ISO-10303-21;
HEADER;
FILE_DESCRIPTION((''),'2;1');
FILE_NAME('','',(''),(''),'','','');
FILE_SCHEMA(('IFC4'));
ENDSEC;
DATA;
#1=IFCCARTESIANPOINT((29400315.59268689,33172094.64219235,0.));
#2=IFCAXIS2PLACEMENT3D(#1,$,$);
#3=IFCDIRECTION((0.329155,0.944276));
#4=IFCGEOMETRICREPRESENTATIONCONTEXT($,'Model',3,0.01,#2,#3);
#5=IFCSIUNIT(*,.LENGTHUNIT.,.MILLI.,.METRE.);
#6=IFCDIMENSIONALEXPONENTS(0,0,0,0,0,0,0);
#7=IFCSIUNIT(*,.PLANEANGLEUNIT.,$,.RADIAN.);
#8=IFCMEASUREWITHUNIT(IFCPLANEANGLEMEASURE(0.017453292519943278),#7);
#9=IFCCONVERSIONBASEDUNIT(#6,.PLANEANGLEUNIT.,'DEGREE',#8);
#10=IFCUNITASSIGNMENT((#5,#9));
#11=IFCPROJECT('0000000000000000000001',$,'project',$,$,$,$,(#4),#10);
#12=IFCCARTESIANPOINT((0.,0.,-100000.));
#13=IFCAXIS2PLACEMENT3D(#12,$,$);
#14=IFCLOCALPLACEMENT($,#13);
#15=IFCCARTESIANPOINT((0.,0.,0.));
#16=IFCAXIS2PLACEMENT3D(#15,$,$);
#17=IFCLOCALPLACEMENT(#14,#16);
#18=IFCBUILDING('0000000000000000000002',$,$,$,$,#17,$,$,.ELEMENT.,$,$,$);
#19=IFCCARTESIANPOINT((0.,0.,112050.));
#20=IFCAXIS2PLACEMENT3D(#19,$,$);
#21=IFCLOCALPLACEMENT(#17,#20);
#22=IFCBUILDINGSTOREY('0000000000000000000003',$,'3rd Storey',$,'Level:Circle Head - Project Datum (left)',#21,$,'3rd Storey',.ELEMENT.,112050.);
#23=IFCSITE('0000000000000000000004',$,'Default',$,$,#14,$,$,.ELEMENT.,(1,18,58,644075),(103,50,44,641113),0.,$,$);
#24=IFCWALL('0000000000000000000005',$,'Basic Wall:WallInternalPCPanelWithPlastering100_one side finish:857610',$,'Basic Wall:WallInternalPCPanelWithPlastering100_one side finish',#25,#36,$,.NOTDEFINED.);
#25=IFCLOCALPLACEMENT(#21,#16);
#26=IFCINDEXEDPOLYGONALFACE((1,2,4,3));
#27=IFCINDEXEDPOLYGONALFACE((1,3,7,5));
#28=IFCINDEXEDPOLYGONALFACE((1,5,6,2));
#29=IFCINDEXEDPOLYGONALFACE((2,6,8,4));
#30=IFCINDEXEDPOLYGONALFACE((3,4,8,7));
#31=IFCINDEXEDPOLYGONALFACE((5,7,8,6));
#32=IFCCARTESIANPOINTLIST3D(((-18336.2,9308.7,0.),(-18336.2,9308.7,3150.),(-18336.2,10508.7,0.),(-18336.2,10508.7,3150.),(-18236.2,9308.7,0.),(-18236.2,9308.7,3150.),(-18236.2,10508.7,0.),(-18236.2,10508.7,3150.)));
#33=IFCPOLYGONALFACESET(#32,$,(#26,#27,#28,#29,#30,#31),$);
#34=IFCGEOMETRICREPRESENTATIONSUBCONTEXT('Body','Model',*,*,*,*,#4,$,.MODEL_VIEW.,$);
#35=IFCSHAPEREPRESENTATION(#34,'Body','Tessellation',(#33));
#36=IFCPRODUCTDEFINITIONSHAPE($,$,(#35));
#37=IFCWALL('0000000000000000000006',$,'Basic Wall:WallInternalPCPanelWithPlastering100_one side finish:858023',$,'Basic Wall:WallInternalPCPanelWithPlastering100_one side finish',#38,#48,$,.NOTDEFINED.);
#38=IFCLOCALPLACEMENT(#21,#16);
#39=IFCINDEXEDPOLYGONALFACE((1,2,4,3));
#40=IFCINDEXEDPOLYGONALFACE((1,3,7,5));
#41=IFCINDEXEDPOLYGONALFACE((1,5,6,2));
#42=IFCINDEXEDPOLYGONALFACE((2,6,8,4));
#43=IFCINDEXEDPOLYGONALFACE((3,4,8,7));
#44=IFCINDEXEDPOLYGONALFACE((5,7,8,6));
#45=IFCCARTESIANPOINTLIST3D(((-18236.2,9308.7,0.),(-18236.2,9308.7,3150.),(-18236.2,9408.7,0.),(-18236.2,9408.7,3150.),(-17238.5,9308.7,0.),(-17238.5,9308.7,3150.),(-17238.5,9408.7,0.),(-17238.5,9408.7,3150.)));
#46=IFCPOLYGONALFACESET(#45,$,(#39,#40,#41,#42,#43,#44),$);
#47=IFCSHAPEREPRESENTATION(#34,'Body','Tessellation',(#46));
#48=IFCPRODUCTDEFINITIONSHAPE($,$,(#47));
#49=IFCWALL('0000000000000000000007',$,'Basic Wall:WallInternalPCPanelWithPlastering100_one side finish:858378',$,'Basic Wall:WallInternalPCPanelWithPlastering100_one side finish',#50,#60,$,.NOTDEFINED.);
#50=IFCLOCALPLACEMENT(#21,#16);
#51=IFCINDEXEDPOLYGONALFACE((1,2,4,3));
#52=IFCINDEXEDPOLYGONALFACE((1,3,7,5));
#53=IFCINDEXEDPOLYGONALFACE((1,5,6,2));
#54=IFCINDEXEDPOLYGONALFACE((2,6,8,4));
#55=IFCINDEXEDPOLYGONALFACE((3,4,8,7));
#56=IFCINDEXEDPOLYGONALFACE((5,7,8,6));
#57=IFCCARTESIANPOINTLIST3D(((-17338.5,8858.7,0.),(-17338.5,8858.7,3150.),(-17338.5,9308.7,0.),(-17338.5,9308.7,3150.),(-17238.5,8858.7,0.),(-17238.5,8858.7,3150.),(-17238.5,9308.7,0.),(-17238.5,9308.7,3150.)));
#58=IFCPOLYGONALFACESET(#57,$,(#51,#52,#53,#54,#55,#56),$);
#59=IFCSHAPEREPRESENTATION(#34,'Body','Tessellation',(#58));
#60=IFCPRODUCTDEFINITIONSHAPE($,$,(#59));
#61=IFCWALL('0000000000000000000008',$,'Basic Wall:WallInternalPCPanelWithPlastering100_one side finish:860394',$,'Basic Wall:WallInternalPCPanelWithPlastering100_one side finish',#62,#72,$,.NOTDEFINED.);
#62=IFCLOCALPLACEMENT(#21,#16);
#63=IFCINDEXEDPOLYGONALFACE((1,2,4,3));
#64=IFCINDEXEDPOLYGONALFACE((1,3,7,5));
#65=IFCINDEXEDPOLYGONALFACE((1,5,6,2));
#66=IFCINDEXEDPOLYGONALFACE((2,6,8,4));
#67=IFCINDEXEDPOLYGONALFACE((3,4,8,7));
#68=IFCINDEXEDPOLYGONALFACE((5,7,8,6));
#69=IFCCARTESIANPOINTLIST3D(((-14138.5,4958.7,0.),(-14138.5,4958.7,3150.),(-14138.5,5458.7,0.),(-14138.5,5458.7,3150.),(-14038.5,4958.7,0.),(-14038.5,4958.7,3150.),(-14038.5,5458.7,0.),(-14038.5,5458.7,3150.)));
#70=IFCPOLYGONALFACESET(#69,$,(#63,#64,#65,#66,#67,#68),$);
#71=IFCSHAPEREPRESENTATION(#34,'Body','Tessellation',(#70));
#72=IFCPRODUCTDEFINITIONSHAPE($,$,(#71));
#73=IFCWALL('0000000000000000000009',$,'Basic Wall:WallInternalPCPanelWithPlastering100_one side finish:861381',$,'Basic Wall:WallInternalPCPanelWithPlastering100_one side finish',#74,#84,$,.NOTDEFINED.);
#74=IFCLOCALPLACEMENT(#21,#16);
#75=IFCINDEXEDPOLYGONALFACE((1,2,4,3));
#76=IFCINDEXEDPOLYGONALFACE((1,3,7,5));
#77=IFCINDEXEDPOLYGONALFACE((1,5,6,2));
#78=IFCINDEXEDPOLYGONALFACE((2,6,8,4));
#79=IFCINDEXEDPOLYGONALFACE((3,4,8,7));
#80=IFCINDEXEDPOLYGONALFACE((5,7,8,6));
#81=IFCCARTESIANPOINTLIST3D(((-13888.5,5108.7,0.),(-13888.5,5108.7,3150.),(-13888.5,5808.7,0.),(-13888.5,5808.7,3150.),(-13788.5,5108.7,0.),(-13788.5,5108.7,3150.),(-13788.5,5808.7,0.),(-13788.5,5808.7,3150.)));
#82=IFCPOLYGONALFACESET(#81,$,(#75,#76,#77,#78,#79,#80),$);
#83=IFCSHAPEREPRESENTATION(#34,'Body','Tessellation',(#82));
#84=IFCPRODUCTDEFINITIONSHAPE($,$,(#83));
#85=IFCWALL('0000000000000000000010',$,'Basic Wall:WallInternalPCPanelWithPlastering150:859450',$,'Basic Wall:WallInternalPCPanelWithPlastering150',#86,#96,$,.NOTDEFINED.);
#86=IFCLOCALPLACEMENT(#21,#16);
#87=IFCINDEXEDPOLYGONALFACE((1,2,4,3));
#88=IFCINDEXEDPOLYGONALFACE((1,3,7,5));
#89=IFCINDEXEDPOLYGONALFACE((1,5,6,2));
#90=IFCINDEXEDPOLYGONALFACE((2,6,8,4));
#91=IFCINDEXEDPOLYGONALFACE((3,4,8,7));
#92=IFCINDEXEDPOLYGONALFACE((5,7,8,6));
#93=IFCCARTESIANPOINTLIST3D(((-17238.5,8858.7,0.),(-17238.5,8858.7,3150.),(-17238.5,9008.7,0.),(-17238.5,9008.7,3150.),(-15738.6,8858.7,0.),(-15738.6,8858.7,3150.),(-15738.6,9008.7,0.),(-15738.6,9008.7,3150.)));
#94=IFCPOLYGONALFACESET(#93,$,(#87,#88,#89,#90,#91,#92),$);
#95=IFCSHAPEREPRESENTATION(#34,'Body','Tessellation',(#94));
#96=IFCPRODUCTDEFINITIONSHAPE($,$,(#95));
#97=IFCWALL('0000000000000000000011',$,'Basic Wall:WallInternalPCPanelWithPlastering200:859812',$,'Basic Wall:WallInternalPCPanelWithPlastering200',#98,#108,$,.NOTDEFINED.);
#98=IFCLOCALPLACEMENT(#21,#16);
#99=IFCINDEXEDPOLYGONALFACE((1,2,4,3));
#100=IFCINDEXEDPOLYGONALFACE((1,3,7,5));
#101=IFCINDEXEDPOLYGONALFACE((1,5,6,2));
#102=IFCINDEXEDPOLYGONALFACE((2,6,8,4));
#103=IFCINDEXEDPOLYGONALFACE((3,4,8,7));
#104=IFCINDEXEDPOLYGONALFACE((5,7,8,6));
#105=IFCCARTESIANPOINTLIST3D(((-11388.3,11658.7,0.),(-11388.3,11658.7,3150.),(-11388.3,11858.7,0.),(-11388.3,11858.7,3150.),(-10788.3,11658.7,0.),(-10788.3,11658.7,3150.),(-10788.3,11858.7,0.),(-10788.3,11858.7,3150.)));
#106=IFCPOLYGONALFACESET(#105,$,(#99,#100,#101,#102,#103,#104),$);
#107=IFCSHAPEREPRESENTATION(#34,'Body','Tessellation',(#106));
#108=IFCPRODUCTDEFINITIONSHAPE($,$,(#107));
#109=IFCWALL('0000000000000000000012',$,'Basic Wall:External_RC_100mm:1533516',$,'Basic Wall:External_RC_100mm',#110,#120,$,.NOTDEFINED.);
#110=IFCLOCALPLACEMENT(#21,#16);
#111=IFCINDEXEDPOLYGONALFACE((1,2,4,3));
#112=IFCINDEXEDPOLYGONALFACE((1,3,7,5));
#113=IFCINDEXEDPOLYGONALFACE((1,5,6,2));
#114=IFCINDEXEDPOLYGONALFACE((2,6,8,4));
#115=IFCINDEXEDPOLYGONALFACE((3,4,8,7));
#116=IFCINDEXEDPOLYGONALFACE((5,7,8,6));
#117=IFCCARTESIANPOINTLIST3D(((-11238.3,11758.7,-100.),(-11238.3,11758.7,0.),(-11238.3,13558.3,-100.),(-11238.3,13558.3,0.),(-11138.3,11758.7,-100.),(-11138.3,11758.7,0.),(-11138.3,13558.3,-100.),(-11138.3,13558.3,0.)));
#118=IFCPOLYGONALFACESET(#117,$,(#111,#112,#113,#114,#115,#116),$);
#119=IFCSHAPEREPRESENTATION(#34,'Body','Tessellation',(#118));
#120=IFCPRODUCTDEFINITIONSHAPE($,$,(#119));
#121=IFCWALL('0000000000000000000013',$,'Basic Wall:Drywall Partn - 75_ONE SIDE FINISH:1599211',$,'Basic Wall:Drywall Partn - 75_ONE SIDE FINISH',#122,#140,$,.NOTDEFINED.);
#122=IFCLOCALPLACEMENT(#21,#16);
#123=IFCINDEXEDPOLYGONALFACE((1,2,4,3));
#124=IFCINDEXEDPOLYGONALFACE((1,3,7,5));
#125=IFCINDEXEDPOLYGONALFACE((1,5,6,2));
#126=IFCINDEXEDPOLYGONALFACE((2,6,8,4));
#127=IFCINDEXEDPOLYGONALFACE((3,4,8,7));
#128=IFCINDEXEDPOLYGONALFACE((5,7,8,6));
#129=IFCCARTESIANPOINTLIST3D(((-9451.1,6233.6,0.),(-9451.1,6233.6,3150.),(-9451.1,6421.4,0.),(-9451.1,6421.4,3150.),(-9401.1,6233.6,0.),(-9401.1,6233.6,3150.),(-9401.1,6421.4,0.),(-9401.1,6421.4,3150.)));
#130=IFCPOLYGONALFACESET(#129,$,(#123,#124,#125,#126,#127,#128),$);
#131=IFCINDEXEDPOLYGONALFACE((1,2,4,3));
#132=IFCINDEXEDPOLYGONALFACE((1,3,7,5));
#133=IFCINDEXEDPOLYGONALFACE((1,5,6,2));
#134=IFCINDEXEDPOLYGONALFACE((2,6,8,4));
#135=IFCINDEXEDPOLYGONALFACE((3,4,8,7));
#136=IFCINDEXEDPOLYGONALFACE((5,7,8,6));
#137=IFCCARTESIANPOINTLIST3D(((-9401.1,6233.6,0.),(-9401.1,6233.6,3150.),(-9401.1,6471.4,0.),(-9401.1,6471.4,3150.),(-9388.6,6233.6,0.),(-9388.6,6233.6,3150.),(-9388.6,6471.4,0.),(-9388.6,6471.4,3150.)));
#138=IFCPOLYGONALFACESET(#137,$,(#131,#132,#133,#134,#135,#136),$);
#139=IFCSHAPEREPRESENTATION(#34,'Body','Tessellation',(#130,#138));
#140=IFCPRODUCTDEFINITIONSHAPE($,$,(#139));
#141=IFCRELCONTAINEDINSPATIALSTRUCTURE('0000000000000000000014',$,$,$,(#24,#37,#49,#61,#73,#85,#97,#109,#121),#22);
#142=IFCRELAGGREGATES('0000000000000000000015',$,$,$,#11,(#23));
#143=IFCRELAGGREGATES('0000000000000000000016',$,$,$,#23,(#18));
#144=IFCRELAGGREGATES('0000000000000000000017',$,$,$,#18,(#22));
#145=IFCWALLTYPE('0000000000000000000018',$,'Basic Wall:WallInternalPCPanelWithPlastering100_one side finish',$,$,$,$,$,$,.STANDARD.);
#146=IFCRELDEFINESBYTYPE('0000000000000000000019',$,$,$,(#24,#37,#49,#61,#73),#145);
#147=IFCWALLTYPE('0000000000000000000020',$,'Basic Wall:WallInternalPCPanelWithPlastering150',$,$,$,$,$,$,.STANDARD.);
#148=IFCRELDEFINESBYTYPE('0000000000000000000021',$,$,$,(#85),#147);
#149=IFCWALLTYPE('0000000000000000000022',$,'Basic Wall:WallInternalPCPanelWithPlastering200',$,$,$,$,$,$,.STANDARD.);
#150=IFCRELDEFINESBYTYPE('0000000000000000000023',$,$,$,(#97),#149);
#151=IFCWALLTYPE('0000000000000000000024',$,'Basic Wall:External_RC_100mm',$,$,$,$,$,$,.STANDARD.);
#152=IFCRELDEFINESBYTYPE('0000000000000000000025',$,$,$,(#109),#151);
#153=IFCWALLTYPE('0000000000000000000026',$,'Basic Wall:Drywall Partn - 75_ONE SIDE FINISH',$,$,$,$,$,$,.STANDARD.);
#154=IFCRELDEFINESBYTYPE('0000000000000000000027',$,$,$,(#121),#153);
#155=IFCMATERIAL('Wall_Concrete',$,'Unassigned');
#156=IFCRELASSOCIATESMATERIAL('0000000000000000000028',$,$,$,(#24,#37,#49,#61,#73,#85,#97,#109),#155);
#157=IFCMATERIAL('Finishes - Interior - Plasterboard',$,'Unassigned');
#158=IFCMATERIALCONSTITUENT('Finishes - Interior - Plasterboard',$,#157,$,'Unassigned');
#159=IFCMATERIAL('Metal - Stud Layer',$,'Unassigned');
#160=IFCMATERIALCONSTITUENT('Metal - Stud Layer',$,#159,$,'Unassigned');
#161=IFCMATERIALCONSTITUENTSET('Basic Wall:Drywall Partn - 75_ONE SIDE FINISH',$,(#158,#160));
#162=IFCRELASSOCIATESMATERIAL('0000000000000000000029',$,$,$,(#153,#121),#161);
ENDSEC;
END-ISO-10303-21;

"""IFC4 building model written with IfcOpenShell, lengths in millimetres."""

from ifc_helpers import new_model, entity, si_unit, converted_unit, direction, frame, origin, place, context, subcontext, project, spatial, indexed_curve, outline, extrude, material, constituent, constituent_set, type_object, element, save


model = new_model("IFC4")

# Units and contexts
model_context = context("Model", 3, precision=0.01, world=frame((29400315.59268689, 33172094.64219235, 0.0)), true_north=direction((0.329155, 0.944276)))
body_context = subcontext(model_context, "Body", "Model", "MODEL_VIEW")
ifc_project = project(units=[si_unit("LENGTHUNIT", "METRE", prefix="MILLI"), converted_unit("PLANEANGLEUNIT", "DEGREE", entity("IfcPlaneAngleMeasure", 0.017453292519943278), si_unit("PLANEANGLEUNIT", "RADIAN"), dimensions=[0, 0, 0, 0, 0, 0, 0])], contexts=[model_context])

# Site, building, storey
site_placement = place(None, frame((0.0, 0.0, -100000.0)))
site = spatial("IfcSite", under=ifc_project, at=site_placement, Name="Default", CompositionType="ELEMENT", RefLatitude=(1, 18, 58, 644075), RefLongitude=(103, 50, 44, 641113), RefElevation=0.0)
building_placement = place(site_placement, origin())
building = spatial("IfcBuilding", under=site, at=building_placement, CompositionType="ELEMENT")
storey_placement = place(building_placement, frame((0.0, 0.0, 112050.0)))
storey = spatial("IfcBuildingStorey", under=building, at=storey_placement, Name="3rd Storey", ObjectType="Level:Circle Head - Project Datum (left)", LongName="3rd Storey", CompositionType="ELEMENT", Elevation=112050.0)

# Walls
ifc_material_1 = material(Name="Wall_Concrete", Category="Unassigned")
ifc_material_2 = material(Name="Metal - Stud Layer", Category="Unassigned")
wall_type_1 = type_object("IfcWallType", Name="Basic Wall:WallInternalPCPanelWithPlastering100_one side finish", PredefinedType="STANDARD")
wall_1_placement = place(storey_placement, frame((-18286.2, 9308.7, 0.0), z_axis=(0.0, 0.0, 1.0), x_axis=(0.0, 1.0, 0.0)))
element("IfcWall", 1, at=wall_1_placement, inside=storey, type_object=wall_type_1, material=ifc_material_1, Name="Basic Wall:WallInternalPCPanelWithPlastering100_one side finish:857610", ObjectType="Basic Wall:WallInternalPCPanelWithPlastering100_one side finish", PredefinedType="NOTDEFINED", context=body_context, shape_type="SweptSolid", body=[
    extrude(outline(indexed_curve([(1200.0, 50.0), (0.0, 50.0), (0.0, -50.0), (1200.0, -50.0), (1200.0, 50.0)], self_intersect=False)), origin(), (0.0, 0.0, 1.0), 3150.0),
])
wall_2_placement = place(storey_placement, frame((-17238.5, 9358.7, 0.0), z_axis=(0.0, 0.0, 1.0), x_axis=(-1.0, 0.0, 0.0)))
element("IfcWall", 2, at=wall_2_placement, inside=storey, type_object=wall_type_1, material=ifc_material_1, Name="Basic Wall:WallInternalPCPanelWithPlastering100_one side finish:858023", ObjectType="Basic Wall:WallInternalPCPanelWithPlastering100_one side finish", PredefinedType="NOTDEFINED", context=body_context, shape_type="SweptSolid", body=[
    extrude(outline(indexed_curve([(997.7, 50.0), (0.0, 50.0), (0.0, -50.0), (997.7, -50.0), (997.7, 50.0)], self_intersect=False)), origin(), (0.0, 0.0, 1.0), 3150.0),
])
wall_3_placement = place(storey_placement, frame((-17288.5, 8858.7, 0.0), z_axis=(0.0, 0.0, 1.0), x_axis=(0.0, 1.0, 0.0)))
element("IfcWall", 3, at=wall_3_placement, inside=storey, type_object=wall_type_1, material=ifc_material_1, Name="Basic Wall:WallInternalPCPanelWithPlastering100_one side finish:858378", ObjectType="Basic Wall:WallInternalPCPanelWithPlastering100_one side finish", PredefinedType="NOTDEFINED", context=body_context, shape_type="SweptSolid", body=[
    extrude(outline(indexed_curve([(450.0, 50.0), (0.0, 50.0), (0.0, -50.0), (450.0, -50.0), (450.0, 50.0)], self_intersect=False)), origin(), (0.0, 0.0, 1.0), 3150.0),
])
wall_4_placement = place(storey_placement, frame((-14088.5, 5458.7, 0.0), z_axis=(0.0, 0.0, 1.0), x_axis=(0.0, -1.0, 0.0)))
element("IfcWall", 4, at=wall_4_placement, inside=storey, type_object=wall_type_1, material=ifc_material_1, Name="Basic Wall:WallInternalPCPanelWithPlastering100_one side finish:860394", ObjectType="Basic Wall:WallInternalPCPanelWithPlastering100_one side finish", PredefinedType="NOTDEFINED", context=body_context, shape_type="SweptSolid", body=[
    extrude(outline(indexed_curve([(500.0, 50.0), (0.0, 50.0), (0.0, -50.0), (500.0, -50.0), (500.0, 50.0)], self_intersect=False)), origin(), (0.0, 0.0, 1.0), 3150.0),
])
wall_5_placement = place(storey_placement, frame((-13838.5, 5108.7, 0.0), z_axis=(0.0, 0.0, 1.0), x_axis=(0.0, 1.0, 0.0)))
element("IfcWall", 5, at=wall_5_placement, inside=storey, type_object=wall_type_1, material=ifc_material_1, Name="Basic Wall:WallInternalPCPanelWithPlastering100_one side finish:861381", ObjectType="Basic Wall:WallInternalPCPanelWithPlastering100_one side finish", PredefinedType="NOTDEFINED", context=body_context, shape_type="SweptSolid", body=[
    extrude(outline(indexed_curve([(700.0, 50.0), (0.0, 50.0), (0.0, -50.0), (700.0, -50.0), (700.0, 50.0)], self_intersect=False)), origin(), (0.0, 0.0, 1.0), 3150.0),
])
wall_type_2 = type_object("IfcWallType", Name="Basic Wall:WallInternalPCPanelWithPlastering150", PredefinedType="STANDARD")
wall_6_placement = place(storey_placement, frame((-17238.5, 8933.7, 0.0)))
element("IfcWall", 6, at=wall_6_placement, inside=storey, type_object=wall_type_2, material=ifc_material_1, Name="Basic Wall:WallInternalPCPanelWithPlastering150:859450", ObjectType="Basic Wall:WallInternalPCPanelWithPlastering150", PredefinedType="NOTDEFINED", context=body_context, shape_type="SweptSolid", body=[
    extrude(outline(indexed_curve([(1499.9, 75.0), (0.0, 75.0), (0.0, -75.0), (1499.9, -75.0), (1499.9, 75.0)], self_intersect=False)), origin(), (0.0, 0.0, 1.0), 3150.0),
])
wall_type_3 = type_object("IfcWallType", Name="Basic Wall:WallInternalPCPanelWithPlastering200", PredefinedType="STANDARD")
wall_7_placement = place(storey_placement, frame((-10788.3, 11758.7, 0.0), z_axis=(0.0, 0.0, 1.0), x_axis=(-1.0, 0.0, 0.0)))
element("IfcWall", 7, at=wall_7_placement, inside=storey, type_object=wall_type_3, material=ifc_material_1, Name="Basic Wall:WallInternalPCPanelWithPlastering200:859812", ObjectType="Basic Wall:WallInternalPCPanelWithPlastering200", PredefinedType="NOTDEFINED", context=body_context, shape_type="SweptSolid", body=[
    extrude(outline(indexed_curve([(600.0, 100.0), (0.0, 100.0), (0.0, -100.0), (600.0, -100.0), (600.0, 100.0)], self_intersect=False)), origin(), (0.0, 0.0, 1.0), 3150.0),
])
wall_type_4 = type_object("IfcWallType", Name="Basic Wall:External_RC_100mm", PredefinedType="STANDARD")
wall_8_placement = place(storey_placement, frame((-11188.3, 13558.3, -100.0), z_axis=(0.0, 0.0, 1.0), x_axis=(0.0, -1.0, 0.0)))
element("IfcWall", 8, at=wall_8_placement, inside=storey, type_object=wall_type_4, material=ifc_material_1, Name="Basic Wall:External_RC_100mm:1533516", ObjectType="Basic Wall:External_RC_100mm", PredefinedType="NOTDEFINED", context=body_context, shape_type="SweptSolid", body=[
    extrude(outline(indexed_curve([(1799.6, 50.0), (0.0, 50.0), (0.0, -50.0), (1799.6, -50.0), (1799.6, 50.0)], self_intersect=False)), origin(), (0.0, 0.0, 1.0), 100.0),
])
ifc_material_3 = material(Name="Finishes - Interior - Plasterboard", Category="Unassigned")
ifc_constituent_1 = constituent(ifc_material_3, Name="Finishes - Interior - Plasterboard", Category="Unassigned")
ifc_constituent_2 = constituent(ifc_material_2, Name="Metal - Stud Layer", Category="Unassigned")
ifc_constituent_set = constituent_set(constituents=[ifc_constituent_1, ifc_constituent_2], Name="Basic Wall:Drywall Partn - 75_ONE SIDE FINISH")
wall_type_5 = type_object("IfcWallType", Name="Basic Wall:Drywall Partn - 75_ONE SIDE FINISH", PredefinedType="STANDARD", material=ifc_constituent_set)
wall_9_placement = place(storey_placement, frame((-9419.8, 6421.4, 0.0), z_axis=(0.0, 0.0, 1.0), x_axis=(0.0, -1.0, 0.0)))
element("IfcWall", 9, at=wall_9_placement, inside=storey, type_object=wall_type_5, material=ifc_constituent_set, Name="Basic Wall:Drywall Partn - 75_ONE SIDE FINISH:1599211", ObjectType="Basic Wall:Drywall Partn - 75_ONE SIDE FINISH", PredefinedType="NOTDEFINED", context=body_context, shape_type="SweptSolid", body=[
    extrude(outline(indexed_curve([(-25.0, -93.9), (25.0, -93.9), (25.0, 93.9), (-25.0, 93.9), (-25.0, -93.9)], self_intersect=False)), frame((93.9, -6.2, 0.0), z_axis=(0.0, 0.0, 1.0), x_axis=(0.0, 1.0, 0.0)), (0.0, 0.0, 1.0), 3150.0),
    extrude(outline(indexed_curve([(-6.3, -118.9), (6.2, -118.9), (6.2, 118.9), (-6.3, 118.9), (-6.3, -118.9)], self_intersect=False)), frame((68.9, 25.0, 0.0), z_axis=(0.0, 0.0, 1.0), x_axis=(0.0, -1.0, 0.0)), (0.0, 0.0, 1.0), 3150.0),
])

save(model, "model.ifc")
